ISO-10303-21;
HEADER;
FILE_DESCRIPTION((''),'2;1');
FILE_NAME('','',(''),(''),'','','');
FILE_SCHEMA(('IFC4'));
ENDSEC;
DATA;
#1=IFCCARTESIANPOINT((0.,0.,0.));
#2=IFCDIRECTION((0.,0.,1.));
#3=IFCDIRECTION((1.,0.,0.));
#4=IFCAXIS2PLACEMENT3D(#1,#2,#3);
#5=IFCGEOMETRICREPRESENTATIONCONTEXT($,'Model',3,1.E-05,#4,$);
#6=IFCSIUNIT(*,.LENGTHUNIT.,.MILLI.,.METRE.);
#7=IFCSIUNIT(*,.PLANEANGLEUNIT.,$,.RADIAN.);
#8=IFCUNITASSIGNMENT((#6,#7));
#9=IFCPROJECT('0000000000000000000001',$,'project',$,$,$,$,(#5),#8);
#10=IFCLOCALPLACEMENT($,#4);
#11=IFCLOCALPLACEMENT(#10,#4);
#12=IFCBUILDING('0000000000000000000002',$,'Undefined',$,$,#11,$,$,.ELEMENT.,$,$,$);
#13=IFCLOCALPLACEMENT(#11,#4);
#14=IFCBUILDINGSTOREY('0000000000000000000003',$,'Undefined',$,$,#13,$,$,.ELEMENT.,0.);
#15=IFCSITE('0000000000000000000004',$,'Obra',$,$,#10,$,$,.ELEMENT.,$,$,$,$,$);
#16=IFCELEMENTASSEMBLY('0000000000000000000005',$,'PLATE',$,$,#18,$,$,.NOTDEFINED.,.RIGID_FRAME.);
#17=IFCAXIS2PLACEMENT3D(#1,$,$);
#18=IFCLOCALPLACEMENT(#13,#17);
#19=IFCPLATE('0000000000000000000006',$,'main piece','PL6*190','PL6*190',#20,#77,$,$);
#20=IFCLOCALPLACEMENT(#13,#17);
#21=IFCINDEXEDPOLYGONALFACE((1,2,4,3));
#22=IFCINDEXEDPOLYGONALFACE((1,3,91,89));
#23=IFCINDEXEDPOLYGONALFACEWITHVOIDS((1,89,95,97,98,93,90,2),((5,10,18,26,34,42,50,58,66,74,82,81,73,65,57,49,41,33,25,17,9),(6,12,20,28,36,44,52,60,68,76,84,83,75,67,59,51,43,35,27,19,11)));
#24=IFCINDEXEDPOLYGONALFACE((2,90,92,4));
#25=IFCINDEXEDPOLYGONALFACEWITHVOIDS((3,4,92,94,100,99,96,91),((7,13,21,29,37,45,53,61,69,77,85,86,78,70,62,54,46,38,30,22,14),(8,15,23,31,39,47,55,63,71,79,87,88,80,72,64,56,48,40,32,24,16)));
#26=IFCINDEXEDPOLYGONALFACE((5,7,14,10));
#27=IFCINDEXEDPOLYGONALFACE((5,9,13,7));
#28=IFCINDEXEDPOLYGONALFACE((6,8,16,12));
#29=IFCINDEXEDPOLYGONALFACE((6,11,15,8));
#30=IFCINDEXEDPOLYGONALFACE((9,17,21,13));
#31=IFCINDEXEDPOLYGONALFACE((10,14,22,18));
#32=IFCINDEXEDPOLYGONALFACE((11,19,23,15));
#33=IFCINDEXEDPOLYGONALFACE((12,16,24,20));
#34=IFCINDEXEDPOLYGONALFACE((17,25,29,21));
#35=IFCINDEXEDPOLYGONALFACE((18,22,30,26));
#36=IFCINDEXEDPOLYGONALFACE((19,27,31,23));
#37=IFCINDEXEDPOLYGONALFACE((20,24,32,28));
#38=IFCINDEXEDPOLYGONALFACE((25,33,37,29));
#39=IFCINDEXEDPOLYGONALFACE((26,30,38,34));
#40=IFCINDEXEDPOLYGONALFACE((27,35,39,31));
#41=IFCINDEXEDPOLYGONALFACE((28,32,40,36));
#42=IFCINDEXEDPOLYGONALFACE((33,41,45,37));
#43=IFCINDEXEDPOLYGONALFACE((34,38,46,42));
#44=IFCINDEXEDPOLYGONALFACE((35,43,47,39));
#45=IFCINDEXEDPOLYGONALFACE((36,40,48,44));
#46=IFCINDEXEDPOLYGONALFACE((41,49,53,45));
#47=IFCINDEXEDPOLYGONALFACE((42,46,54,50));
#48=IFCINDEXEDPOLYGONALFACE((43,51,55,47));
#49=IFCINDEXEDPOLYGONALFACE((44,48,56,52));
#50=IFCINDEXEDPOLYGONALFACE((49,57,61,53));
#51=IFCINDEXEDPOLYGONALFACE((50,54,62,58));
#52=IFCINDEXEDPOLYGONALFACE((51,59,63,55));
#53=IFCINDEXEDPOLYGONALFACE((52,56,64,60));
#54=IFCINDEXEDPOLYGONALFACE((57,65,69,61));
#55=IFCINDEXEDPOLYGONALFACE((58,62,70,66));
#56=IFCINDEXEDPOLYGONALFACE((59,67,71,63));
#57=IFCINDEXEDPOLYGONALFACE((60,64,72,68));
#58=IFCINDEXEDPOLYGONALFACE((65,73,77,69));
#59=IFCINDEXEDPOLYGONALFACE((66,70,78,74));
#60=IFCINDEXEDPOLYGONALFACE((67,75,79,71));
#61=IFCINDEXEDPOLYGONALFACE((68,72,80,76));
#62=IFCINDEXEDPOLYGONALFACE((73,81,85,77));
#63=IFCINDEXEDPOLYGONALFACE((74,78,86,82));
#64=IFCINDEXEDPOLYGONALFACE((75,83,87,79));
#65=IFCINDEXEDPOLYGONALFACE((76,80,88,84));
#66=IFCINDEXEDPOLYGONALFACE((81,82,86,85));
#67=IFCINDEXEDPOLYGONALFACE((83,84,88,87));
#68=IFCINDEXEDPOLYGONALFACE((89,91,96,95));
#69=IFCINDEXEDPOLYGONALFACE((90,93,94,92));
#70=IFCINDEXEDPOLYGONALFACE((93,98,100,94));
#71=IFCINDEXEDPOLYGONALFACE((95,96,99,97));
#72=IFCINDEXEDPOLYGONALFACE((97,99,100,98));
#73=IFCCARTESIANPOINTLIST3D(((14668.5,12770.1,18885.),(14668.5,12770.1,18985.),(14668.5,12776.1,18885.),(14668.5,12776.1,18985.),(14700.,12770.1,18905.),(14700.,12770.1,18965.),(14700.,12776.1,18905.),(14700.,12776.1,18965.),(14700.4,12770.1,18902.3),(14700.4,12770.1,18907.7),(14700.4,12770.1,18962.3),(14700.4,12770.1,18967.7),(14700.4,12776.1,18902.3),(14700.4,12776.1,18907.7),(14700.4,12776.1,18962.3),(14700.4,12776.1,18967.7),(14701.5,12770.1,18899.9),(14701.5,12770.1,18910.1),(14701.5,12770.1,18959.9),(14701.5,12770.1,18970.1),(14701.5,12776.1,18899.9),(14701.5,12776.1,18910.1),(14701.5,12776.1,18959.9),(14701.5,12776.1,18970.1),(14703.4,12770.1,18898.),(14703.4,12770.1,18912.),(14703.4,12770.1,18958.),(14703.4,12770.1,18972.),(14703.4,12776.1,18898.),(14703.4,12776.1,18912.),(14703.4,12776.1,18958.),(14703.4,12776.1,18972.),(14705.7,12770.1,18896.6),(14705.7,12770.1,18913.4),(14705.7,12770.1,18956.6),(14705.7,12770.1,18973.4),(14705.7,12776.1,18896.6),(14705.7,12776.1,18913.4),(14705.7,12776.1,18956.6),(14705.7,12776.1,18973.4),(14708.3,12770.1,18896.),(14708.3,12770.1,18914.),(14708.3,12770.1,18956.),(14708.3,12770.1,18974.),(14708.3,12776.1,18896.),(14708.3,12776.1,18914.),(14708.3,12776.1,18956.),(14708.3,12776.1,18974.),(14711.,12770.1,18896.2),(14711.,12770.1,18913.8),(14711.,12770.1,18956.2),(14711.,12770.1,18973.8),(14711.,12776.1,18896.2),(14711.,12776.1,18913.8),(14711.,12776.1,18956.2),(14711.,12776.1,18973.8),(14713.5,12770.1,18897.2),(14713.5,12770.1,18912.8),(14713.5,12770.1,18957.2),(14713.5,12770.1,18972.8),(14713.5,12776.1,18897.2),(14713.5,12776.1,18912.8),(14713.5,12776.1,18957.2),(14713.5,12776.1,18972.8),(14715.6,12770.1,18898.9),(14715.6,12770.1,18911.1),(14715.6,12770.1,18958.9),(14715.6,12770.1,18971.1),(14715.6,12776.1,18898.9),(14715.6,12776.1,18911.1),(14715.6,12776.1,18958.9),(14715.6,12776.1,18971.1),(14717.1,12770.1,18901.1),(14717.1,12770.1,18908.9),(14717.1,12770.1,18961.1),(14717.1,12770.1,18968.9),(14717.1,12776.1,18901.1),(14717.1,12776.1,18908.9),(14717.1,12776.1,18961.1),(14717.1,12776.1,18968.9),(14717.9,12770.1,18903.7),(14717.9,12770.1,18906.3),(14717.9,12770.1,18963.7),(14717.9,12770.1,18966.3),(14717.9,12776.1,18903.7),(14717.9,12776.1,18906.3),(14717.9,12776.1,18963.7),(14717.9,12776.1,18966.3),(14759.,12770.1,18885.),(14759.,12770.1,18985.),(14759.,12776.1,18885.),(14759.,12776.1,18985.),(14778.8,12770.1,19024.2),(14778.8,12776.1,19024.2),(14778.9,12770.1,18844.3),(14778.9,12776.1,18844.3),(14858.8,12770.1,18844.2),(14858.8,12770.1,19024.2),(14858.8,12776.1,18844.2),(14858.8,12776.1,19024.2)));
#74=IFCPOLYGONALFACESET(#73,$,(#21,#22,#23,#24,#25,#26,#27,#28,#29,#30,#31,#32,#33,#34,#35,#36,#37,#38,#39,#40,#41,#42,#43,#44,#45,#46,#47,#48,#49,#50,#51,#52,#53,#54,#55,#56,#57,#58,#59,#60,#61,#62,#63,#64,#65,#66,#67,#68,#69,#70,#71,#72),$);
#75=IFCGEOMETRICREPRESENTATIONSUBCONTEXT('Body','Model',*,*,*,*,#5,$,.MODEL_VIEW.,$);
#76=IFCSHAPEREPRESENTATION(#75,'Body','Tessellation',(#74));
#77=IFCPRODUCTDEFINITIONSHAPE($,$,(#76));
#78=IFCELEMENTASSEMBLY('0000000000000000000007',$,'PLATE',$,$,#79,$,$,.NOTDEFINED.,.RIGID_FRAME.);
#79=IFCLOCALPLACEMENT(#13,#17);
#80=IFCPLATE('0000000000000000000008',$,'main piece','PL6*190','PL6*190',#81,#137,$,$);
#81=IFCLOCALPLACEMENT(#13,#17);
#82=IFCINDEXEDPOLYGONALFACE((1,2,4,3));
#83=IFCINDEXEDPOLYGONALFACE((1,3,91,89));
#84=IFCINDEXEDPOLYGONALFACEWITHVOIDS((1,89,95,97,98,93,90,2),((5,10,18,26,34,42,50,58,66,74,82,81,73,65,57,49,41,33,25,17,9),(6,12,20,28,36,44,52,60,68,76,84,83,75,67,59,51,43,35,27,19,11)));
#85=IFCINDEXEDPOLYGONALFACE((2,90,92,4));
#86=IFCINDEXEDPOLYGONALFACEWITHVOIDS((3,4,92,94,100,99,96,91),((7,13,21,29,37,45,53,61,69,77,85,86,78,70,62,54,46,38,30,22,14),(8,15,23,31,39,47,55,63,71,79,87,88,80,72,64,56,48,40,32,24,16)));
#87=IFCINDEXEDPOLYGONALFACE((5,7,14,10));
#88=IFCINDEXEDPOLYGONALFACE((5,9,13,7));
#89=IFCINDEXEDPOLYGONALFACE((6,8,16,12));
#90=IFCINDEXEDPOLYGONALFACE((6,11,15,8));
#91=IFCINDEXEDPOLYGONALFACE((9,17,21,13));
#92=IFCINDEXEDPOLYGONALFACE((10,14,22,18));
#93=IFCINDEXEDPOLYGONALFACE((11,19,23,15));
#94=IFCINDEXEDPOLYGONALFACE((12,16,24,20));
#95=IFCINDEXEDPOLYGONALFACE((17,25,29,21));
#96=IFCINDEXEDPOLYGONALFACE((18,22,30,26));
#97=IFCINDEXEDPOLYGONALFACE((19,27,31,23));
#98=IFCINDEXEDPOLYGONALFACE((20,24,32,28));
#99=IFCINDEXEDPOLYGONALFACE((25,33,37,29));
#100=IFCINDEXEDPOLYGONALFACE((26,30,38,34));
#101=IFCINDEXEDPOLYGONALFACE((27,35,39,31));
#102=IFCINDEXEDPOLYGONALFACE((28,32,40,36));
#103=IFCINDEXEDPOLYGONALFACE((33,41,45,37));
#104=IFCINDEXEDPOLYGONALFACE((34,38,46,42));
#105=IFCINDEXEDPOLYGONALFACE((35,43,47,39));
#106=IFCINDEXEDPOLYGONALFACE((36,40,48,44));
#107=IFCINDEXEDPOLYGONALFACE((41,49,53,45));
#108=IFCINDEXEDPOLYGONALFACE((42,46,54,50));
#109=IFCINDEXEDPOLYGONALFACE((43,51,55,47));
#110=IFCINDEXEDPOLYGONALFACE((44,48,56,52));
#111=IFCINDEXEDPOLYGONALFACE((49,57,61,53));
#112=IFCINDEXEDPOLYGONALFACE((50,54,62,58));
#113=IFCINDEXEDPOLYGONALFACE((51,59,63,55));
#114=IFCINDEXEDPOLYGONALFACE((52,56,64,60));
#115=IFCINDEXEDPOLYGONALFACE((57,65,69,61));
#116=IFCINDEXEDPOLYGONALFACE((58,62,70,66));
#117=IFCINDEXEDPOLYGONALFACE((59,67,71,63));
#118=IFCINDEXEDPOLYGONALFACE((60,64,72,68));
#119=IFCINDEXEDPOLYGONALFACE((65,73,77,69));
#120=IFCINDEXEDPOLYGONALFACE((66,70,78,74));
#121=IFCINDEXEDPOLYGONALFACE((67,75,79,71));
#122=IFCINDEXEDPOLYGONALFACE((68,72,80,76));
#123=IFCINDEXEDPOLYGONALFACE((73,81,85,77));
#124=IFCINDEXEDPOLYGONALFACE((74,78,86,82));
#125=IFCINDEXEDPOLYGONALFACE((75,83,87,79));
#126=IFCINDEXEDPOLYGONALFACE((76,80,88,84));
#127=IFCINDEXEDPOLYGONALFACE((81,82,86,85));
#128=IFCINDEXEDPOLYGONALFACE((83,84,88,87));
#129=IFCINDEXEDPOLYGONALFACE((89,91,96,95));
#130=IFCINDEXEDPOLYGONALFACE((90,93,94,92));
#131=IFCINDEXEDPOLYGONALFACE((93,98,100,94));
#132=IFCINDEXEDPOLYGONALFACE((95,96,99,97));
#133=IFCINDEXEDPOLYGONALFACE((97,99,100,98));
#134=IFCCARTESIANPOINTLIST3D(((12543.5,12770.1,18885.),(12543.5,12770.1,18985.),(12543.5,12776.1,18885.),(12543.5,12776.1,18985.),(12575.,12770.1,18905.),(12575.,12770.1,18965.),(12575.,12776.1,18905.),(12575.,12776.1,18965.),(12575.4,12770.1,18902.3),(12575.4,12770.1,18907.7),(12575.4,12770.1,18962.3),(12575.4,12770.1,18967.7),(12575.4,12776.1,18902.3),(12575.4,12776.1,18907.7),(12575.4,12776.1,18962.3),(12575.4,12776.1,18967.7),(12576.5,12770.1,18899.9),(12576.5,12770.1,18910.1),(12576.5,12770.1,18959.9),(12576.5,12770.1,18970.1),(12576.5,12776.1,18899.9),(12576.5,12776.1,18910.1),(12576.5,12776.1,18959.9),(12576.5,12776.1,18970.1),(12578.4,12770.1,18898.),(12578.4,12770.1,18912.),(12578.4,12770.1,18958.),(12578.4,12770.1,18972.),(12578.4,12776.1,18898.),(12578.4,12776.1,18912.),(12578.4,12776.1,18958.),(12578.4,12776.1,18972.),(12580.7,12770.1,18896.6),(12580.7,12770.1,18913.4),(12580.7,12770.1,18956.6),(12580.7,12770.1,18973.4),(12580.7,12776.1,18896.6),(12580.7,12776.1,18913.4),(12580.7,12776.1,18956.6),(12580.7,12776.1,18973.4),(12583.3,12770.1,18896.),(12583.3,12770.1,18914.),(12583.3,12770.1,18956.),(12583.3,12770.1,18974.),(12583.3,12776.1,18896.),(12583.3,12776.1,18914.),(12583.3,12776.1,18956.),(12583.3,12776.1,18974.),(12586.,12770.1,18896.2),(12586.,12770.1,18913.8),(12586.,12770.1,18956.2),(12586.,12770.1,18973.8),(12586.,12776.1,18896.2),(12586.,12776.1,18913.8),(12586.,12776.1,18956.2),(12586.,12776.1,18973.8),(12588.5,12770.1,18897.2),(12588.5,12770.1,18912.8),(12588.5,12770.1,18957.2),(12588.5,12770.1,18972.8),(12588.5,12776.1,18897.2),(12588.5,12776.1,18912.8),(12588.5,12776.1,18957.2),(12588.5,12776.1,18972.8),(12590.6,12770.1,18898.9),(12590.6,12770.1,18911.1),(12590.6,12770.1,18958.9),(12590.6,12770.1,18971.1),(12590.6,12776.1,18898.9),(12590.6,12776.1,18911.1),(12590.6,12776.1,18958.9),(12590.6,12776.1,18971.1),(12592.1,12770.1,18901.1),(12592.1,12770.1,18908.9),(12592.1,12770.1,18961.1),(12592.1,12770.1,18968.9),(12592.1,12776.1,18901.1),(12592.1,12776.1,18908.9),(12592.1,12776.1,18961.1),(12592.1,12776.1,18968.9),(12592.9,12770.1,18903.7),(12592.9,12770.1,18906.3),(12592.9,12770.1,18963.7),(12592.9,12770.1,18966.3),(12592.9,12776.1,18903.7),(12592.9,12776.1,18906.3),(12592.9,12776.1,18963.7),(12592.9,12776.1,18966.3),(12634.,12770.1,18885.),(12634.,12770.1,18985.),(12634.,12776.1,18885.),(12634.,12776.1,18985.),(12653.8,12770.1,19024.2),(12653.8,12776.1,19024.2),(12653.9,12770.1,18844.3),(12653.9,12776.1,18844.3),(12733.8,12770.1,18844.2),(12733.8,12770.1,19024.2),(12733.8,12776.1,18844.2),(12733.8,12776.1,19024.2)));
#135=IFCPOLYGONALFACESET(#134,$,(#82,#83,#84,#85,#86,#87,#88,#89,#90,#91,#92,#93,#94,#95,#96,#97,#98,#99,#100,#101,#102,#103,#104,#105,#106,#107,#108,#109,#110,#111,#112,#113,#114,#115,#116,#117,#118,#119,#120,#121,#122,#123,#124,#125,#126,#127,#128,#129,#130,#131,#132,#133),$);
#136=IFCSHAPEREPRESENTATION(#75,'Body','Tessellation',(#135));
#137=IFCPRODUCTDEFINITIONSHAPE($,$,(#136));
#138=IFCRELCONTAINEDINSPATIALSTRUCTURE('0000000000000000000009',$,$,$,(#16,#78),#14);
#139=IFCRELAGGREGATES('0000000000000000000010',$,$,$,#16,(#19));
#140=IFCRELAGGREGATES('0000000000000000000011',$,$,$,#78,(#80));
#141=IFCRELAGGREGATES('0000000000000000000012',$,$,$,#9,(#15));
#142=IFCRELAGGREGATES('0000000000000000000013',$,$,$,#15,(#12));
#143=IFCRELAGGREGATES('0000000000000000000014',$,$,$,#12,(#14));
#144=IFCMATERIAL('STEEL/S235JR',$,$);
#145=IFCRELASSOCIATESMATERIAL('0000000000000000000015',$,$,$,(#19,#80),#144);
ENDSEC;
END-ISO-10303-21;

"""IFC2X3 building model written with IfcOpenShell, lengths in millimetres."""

from ifc_helpers import new_model, si_unit, frame, origin_with_axes, origin_2d_with_axis, place, context, subcontext, project, spatial, polyline, circle, outline, extrude, source, transform, mapped, material, element, aggregate, save


model = new_model("IFC2X3")

# Units and contexts
model_context = context("Model", 3, precision=1e-05, world=origin_with_axes())
body_context = subcontext(model_context, "Body", "Model", "MODEL_VIEW")
ifc_project = project(units=[si_unit("LENGTHUNIT", "METRE", prefix="MILLI"), si_unit("PLANEANGLEUNIT", "RADIAN")], contexts=[model_context])

# Site, building, storey
site_placement = place(None, origin_with_axes())
site = spatial("IfcSite", under=ifc_project, at=site_placement, Name="Obra", CompositionType="ELEMENT")
building_placement = place(site_placement, origin_with_axes())
building = spatial("IfcBuilding", under=site, at=building_placement, Name="Undefined", CompositionType="ELEMENT")
storey_placement = place(building_placement, origin_with_axes())
storey = spatial("IfcBuildingStorey", under=building, at=storey_placement, Name="Undefined", CompositionType="ELEMENT", Elevation=0.0)

# Shared definitions
ifc_material_1 = material(Name="STEEL/S235JR")

# Element assemblies, plates, openings
assembly_1_placement = place(storey_placement, origin_with_axes())
assembly_1 = element("IfcElementAssembly", 1, at=assembly_1_placement, inside=storey, Name="PLATE", AssemblyPlace="NOTDEFINED", PredefinedType="RIGID_FRAME")
plate_1_placement = place(assembly_1_placement, frame((14858.8, 12773.1, 19024.2), z_axis=(0.0, 1.0, 0.0), x_axis=(0.0, 0.0, -1.0)))
plate_1 = element("IfcPlate", 2, at=plate_1_placement, material=ifc_material_1, Name="main piece", Description="PL6*190", ObjectType="PL6*190", context=body_context, shape_type="SweptSolid", body=[
    extrude(outline(polyline([(0.0, 0.0), (180.0, 0.0), (180.0, 79.9), (139.2, 99.8), (139.2, 190.3), (39.2, 190.3), (39.2, 99.8), (0.0, 80.0), (0.0, 0.0)])), frame((0.0, 0.0, -3.0), z_axis=(0.0, 0.0, 1.0), x_axis=(1.0, 0.0, 0.0)), (0.0, 0.0, 1.0), 6.0),
])
shared_shape_1 = source(origin_with_axes(), body_context, "Body", "SweptSolid", [
    extrude(circle(Radius=9.0, at=origin_2d_with_axis()), frame((0.0, -6.1, 0.0), z_axis=(0.0, 1.0, 0.0), x_axis=(1.0, 0.0, 0.0)), (0.0, 0.0, 1.0), 6.2),
])
opening_1_placement = place(assembly_1_placement, frame((14709.0, 12770.1, 18935.0), z_axis=(0.0, 0.0, 1.0), x_axis=(-1.0, 0.0, 0.0)))
element("IfcOpeningElement", 3, at=opening_1_placement, cuts=plate_1, ObjectType="Opening", context=body_context, shape_type="MappedRepresentation", body=[
    mapped(shared_shape_1, transform((0.0, 0.0, -30.0))),
    mapped(shared_shape_1, transform((0.0, 0.0, 30.0))),
])
assembly_2_placement = place(storey_placement, origin_with_axes())
assembly_2 = element("IfcElementAssembly", 4, at=assembly_2_placement, inside=storey, Name="PLATE", AssemblyPlace="NOTDEFINED", PredefinedType="RIGID_FRAME")
plate_2_placement = place(assembly_2_placement, frame((12733.8, 12773.1, 19024.2), z_axis=(0.0, 1.0, 0.0), x_axis=(0.0, 0.0, -1.0)))
plate_2 = element("IfcPlate", 5, at=plate_2_placement, material=ifc_material_1, Name="main piece", Description="PL6*190", ObjectType="PL6*190", context=body_context, shape_type="SweptSolid", body=[
    extrude(outline(polyline([(0.0, 0.0), (180.0, 0.0), (180.0, 79.9), (139.2, 99.8), (139.2, 190.3), (39.2, 190.3), (39.2, 99.8), (0.0, 80.0), (0.0, 0.0)])), frame((0.0, 0.0, -3.0), z_axis=(0.0, 0.0, 1.0), x_axis=(1.0, 0.0, 0.0)), (0.0, 0.0, 1.0), 6.0),
])
opening_2_placement = place(assembly_2_placement, frame((12584.0, 12770.1, 18935.0), z_axis=(0.0, 0.0, 1.0), x_axis=(-1.0, 0.0, 0.0)))
element("IfcOpeningElement", 6, at=opening_2_placement, cuts=plate_2, ObjectType="Opening", context=body_context, shape_type="MappedRepresentation", body=[
    mapped(shared_shape_1, transform((0.0, 0.0, -30.0))),
    mapped(shared_shape_1, transform((0.0, 0.0, 30.0))),
])

aggregate(assembly_1, [plate_1])
aggregate(assembly_2, [plate_2])

save(model, "model.ifc")
